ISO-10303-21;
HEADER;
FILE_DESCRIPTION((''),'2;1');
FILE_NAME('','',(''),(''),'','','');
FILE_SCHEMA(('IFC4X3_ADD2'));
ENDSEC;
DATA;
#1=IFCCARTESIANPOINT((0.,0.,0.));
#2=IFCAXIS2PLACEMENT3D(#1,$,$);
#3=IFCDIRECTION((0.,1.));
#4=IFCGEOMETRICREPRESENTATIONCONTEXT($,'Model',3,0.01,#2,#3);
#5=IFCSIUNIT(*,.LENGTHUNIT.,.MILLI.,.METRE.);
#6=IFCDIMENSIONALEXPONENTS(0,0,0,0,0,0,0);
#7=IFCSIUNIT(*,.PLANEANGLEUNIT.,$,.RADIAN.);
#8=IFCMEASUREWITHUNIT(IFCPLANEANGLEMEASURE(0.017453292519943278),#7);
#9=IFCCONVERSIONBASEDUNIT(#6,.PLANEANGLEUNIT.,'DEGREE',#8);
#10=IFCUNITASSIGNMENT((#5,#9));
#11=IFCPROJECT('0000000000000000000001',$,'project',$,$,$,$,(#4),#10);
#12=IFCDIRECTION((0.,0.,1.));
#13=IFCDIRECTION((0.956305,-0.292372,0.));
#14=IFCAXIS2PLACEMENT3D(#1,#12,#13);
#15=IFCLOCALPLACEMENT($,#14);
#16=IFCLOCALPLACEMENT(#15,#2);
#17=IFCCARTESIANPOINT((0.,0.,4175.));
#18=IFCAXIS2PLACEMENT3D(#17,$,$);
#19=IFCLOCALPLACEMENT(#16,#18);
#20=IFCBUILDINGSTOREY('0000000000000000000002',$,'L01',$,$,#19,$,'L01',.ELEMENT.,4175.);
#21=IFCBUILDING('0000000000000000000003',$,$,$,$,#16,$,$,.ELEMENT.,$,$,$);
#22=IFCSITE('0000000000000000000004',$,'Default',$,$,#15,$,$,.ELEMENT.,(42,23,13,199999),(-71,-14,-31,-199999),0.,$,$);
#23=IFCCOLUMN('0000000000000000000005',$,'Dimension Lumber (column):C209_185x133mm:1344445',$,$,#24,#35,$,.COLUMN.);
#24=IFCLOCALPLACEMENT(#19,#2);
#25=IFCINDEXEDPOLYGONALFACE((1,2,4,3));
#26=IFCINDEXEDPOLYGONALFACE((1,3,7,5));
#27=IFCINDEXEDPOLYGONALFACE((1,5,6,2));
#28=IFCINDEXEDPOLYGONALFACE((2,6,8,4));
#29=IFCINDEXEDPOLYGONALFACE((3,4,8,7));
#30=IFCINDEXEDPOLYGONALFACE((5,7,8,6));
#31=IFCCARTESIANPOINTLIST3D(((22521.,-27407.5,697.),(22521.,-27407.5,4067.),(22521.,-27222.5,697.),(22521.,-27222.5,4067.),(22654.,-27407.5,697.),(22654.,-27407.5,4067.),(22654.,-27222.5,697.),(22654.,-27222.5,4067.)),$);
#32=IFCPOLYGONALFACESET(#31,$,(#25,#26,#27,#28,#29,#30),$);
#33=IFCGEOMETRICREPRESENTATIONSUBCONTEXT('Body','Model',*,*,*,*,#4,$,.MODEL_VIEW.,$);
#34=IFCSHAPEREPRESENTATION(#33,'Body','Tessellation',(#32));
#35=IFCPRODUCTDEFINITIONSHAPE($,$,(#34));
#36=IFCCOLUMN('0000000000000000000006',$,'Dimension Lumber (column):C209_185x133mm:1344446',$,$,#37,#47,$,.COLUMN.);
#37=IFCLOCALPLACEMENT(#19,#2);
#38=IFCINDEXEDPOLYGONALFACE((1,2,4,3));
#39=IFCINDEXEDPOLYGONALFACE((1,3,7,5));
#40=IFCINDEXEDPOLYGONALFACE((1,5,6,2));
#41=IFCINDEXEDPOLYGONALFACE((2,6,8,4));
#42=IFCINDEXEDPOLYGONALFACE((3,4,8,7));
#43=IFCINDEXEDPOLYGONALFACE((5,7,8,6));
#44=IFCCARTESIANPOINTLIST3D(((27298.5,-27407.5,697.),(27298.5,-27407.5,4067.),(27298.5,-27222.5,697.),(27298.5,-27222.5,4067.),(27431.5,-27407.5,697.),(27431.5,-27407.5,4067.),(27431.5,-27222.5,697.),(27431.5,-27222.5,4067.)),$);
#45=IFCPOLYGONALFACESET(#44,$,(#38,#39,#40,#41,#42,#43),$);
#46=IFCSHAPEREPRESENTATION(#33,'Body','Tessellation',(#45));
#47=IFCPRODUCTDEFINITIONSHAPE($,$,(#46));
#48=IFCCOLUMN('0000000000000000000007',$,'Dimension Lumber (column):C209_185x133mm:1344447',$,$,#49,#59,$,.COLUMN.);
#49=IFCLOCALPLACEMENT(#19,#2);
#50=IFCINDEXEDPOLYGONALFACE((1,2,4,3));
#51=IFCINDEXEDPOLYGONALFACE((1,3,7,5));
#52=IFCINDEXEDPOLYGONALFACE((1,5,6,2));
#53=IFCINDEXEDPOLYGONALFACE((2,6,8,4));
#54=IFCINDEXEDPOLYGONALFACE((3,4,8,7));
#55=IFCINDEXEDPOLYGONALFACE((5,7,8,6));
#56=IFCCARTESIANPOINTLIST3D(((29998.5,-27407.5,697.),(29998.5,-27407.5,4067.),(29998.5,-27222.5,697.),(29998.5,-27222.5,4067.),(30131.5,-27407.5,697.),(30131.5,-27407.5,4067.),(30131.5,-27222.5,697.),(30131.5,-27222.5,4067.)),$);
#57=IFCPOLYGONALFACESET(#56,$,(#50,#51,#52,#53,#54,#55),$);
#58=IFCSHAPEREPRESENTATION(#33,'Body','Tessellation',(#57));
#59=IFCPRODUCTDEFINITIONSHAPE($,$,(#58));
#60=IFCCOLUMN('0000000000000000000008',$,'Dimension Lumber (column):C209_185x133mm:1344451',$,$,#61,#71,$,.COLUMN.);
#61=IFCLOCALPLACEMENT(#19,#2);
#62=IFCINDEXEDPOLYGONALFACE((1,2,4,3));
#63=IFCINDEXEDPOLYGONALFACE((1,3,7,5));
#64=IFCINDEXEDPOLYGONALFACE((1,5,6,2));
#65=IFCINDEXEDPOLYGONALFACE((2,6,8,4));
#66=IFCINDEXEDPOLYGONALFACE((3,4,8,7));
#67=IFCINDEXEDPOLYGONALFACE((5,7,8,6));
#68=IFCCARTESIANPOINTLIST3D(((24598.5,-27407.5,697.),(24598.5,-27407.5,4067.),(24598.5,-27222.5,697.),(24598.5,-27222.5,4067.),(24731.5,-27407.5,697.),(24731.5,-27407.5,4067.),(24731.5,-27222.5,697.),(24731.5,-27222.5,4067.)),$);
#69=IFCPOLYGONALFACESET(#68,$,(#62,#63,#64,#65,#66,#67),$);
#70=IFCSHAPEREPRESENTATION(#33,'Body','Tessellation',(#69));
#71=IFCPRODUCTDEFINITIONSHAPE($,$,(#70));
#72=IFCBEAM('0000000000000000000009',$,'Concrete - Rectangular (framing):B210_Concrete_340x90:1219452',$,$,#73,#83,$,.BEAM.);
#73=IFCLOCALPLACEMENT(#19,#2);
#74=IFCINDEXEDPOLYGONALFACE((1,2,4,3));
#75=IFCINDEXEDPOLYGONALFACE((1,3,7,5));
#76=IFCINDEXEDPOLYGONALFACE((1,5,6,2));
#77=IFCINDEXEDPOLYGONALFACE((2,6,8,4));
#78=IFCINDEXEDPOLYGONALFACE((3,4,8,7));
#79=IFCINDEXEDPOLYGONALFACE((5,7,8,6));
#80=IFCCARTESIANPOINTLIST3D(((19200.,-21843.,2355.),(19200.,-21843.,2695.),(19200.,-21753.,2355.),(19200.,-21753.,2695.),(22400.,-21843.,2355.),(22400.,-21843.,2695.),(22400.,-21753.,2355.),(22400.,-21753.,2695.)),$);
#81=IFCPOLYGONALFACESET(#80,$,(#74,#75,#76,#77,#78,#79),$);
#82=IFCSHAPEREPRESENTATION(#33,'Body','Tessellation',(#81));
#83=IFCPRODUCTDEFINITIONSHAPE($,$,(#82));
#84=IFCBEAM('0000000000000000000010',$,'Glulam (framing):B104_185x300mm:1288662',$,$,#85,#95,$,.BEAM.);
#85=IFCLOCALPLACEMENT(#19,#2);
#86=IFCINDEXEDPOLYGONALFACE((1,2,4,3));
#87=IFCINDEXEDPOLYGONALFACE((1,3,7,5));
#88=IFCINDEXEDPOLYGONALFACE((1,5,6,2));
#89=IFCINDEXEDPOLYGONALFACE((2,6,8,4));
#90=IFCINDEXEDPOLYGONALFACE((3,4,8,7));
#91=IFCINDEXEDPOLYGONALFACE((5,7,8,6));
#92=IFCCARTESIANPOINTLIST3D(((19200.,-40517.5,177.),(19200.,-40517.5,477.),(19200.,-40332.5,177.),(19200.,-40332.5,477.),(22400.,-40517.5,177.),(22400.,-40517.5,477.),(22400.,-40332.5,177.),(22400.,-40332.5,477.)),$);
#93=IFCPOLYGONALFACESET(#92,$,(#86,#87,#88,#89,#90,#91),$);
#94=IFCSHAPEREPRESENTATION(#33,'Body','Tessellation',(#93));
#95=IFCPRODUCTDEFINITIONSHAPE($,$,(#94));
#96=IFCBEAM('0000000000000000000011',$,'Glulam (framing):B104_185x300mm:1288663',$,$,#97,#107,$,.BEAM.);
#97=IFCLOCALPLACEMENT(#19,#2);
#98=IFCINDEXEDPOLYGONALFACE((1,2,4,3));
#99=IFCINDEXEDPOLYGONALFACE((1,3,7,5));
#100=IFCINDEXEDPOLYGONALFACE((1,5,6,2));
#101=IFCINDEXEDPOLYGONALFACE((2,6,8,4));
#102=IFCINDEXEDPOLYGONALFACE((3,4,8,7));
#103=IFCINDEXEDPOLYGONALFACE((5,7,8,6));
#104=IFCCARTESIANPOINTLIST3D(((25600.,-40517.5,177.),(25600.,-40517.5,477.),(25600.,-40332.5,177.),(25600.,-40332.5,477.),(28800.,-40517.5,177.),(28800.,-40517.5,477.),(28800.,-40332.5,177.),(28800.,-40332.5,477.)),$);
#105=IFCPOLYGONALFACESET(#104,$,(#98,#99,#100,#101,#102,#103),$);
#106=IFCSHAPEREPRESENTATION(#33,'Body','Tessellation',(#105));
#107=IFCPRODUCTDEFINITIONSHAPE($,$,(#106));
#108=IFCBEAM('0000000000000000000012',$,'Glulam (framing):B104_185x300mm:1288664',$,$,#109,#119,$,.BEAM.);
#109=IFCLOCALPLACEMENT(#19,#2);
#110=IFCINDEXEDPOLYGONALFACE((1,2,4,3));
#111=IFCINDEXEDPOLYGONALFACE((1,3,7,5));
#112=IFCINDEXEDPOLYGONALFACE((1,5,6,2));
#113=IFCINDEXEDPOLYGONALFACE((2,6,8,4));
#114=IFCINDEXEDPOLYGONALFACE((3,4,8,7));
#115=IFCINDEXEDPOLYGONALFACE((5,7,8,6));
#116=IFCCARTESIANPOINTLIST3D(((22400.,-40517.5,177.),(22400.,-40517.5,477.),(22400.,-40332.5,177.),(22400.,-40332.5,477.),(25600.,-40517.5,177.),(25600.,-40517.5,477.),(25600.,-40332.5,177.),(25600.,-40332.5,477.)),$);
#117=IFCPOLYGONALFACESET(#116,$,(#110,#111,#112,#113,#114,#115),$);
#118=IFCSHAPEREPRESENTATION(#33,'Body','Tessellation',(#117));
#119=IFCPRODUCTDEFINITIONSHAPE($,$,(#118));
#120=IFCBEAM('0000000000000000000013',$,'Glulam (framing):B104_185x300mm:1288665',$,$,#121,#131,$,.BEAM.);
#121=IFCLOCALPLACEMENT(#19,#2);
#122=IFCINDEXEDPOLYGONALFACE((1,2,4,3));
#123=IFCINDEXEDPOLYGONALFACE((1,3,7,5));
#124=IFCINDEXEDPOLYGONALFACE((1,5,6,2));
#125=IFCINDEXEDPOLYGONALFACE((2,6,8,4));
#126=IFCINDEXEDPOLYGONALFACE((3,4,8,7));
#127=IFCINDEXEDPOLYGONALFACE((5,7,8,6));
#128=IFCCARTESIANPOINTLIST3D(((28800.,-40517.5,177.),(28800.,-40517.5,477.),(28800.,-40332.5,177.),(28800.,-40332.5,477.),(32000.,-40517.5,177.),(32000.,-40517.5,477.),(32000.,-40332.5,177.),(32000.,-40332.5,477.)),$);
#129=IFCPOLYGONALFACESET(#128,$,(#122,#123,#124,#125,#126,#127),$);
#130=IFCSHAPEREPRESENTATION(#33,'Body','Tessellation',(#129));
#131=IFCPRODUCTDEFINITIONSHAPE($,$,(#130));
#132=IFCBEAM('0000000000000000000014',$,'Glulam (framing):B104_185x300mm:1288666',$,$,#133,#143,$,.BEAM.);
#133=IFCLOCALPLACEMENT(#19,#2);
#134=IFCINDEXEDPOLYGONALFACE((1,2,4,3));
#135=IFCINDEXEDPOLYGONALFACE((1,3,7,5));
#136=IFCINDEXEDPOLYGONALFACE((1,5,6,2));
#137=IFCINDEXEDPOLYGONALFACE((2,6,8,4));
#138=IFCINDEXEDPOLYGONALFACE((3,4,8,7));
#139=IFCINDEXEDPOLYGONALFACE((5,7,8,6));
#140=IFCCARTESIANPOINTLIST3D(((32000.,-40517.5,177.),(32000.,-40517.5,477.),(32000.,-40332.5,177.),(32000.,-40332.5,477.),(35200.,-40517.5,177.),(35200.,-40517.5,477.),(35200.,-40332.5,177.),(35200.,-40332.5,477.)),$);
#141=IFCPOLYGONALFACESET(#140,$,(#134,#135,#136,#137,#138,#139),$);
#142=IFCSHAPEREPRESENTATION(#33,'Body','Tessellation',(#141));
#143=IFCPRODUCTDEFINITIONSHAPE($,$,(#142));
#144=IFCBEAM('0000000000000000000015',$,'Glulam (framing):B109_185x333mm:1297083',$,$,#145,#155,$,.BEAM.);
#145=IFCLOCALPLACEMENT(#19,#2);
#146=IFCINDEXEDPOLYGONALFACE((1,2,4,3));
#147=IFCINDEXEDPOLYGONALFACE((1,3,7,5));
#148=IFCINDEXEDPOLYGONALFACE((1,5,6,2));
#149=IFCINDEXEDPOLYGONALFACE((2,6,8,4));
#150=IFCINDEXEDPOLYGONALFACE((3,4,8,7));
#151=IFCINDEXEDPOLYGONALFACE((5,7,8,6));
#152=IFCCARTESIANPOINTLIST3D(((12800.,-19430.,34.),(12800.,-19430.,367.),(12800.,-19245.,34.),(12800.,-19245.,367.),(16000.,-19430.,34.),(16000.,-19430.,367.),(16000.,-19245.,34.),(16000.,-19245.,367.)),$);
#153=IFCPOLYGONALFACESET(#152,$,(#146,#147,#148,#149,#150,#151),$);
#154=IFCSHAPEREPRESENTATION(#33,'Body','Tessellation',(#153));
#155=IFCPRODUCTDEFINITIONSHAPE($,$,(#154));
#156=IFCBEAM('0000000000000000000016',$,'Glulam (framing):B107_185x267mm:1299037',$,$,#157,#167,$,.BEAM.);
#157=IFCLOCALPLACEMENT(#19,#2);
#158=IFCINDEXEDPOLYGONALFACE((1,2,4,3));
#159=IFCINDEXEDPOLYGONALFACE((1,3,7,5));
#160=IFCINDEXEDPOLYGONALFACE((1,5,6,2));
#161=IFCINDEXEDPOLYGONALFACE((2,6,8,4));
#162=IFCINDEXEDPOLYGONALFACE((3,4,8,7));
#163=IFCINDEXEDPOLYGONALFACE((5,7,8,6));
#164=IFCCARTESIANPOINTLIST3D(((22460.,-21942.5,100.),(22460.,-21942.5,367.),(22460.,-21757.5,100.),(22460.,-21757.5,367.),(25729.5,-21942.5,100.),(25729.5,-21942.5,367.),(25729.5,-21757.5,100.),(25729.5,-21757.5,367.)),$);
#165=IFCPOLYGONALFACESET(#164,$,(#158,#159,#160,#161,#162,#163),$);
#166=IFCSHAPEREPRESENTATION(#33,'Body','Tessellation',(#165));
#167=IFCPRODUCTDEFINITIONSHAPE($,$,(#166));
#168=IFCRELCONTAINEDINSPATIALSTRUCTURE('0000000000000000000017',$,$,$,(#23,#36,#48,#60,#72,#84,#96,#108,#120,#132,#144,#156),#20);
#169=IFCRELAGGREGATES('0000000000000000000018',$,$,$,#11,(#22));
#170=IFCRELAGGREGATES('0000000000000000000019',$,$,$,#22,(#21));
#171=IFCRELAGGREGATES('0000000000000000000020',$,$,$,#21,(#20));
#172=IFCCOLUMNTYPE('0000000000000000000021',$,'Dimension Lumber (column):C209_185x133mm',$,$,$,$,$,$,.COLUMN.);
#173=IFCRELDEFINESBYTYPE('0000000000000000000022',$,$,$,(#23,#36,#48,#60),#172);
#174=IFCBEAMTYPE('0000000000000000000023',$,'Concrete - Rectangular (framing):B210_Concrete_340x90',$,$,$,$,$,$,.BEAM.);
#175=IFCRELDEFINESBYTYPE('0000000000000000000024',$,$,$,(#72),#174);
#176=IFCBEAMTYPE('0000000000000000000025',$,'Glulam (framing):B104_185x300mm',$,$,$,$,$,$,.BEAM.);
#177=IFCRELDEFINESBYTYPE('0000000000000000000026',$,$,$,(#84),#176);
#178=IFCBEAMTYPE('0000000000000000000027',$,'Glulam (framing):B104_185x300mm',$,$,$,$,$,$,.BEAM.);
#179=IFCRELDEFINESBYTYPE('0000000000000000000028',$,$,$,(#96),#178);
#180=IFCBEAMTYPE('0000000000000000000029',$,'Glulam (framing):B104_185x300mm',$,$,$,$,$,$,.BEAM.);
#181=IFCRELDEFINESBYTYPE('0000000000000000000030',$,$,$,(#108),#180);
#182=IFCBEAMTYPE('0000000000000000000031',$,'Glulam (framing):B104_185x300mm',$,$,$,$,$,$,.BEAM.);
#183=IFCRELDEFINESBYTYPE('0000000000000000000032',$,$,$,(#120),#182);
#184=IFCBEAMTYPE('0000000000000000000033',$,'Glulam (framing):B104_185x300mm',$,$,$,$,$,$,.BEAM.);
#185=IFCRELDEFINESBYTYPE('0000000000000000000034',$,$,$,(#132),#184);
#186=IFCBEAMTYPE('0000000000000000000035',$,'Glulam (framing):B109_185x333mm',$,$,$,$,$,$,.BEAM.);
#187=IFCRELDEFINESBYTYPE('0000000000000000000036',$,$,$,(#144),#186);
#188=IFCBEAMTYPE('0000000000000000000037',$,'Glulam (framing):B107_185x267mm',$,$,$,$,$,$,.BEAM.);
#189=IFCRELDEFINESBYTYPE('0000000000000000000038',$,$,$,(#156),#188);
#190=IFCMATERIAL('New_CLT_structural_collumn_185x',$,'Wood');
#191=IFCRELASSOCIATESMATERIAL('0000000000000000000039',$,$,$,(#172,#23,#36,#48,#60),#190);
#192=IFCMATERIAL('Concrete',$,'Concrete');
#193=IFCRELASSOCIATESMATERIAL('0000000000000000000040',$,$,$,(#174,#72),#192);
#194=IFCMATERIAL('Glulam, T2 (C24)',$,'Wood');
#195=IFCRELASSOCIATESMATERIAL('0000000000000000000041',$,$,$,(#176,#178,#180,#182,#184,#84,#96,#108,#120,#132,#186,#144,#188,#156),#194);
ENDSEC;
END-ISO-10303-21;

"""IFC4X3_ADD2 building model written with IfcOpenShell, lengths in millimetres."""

from ifc_helpers import new_model, entity, si_unit, converted_unit, direction, frame, origin, origin_2d_with_axis, place, context, subcontext, project, spatial, rectangle, extrude, source, transform, mapped, material, material_profile, profile_set, profile_usage, type_object, type_shapes, element, save


model = new_model("IFC4X3_ADD2")

# Units and contexts
model_context = context("Model", 3, precision=0.01, world=origin(), true_north=direction((0.0, 1.0)))
body_context = subcontext(model_context, "Body", "Model", "MODEL_VIEW")
ifc_project = project(units=[si_unit("LENGTHUNIT", "METRE", prefix="MILLI"), converted_unit("PLANEANGLEUNIT", "DEGREE", entity("IfcPlaneAngleMeasure", 0.017453292519943278), si_unit("PLANEANGLEUNIT", "RADIAN"), dimensions=[0, 0, 0, 0, 0, 0, 0])], contexts=[model_context])

# Site, building, storey
site_placement = place(None, frame((0.0, 0.0, 0.0), z_axis=(0.0, 0.0, 1.0), x_axis=(0.956305, -0.292372, 0.0)))
site = spatial("IfcSite", under=ifc_project, at=site_placement, Name="Default", CompositionType="ELEMENT", RefLatitude=(42, 23, 13, 199999), RefLongitude=(-71, -14, -31, -199999), RefElevation=0.0)
building_placement = place(site_placement, origin())
building = spatial("IfcBuilding", under=site, at=building_placement, CompositionType="ELEMENT")
storey_placement = place(building_placement, frame((0.0, 0.0, 4175.0)))
storey = spatial("IfcBuildingStorey", under=building, at=storey_placement, Name="L01", LongName="L01", CompositionType="ELEMENT", Elevation=4175.0)

# Columns
ifc_material_1 = material(Name="New_CLT_structural_collumn_185x", Category="Wood")
ifc_material_profile_1 = material_profile(ifc_material_1, rectangle(XDim=185.0, YDim=133.0, at=origin_2d_with_axis()), Name="C209_185x133mm")
ifc_profile_set_1 = profile_set([ifc_material_profile_1], Name="C209_185x133mm")
ifc_profile_usage_1 = profile_usage(ifc_profile_set_1)
column_type_1 = type_object("IfcColumnType", Name="Dimension Lumber (column):C209_185x133mm", PredefinedType="COLUMN", material=ifc_profile_set_1)
shared_shape_1 = source(origin(), body_context, "Body", "SweptSolid", [
    extrude(rectangle(XDim=185.0, YDim=133.0, at=origin_2d_with_axis()), frame((0.0, 0.0, 4872.0), z_axis=(0.0, 0.0, 1.0), x_axis=(-1.0, 0.0, 0.0)), (0.0, 0.0, 1.0), 3370.0),
])
type_shapes(column_type_1, [shared_shape_1])
for number, where, z_axis, x_axis, name in (
    (1, (22587.5, -27315.0, -4175.0), (0.0, 0.0, 1.0), (0.0, 1.0, 0.0), "Dimension Lumber (column):C209_185x133mm:1344445"),
    (2, (27365.0, -27315.0, -4175.0), (0.0, 0.0, 1.0), (0.0, 1.0, 0.0), "Dimension Lumber (column):C209_185x133mm:1344446"),
    (3, (30065.0, -27315.0, -4175.0), (0.0, 0.0, 1.0), (0.0, 1.0, 0.0), "Dimension Lumber (column):C209_185x133mm:1344447"),
    (4, (24665.0, -27315.0, -4175.0), (0.0, 0.0, 1.0), (0.0, 1.0, 0.0), "Dimension Lumber (column):C209_185x133mm:1344451"),
):
    element("IfcColumn", number, at=place(storey_placement, frame(where, z_axis=z_axis, x_axis=x_axis)), inside=storey, type_object=column_type_1, material=ifc_profile_usage_1, Name=name, PredefinedType="COLUMN", context=body_context, shape_type="MappedRepresentation", body=[
        mapped(shared_shape_1, transform((0.0, 0.0, 0.0), scale=1.0)),
    ])

# Beams
ifc_material_2 = material(Name="Concrete", Category="Concrete")
ifc_material_profile_2 = material_profile(ifc_material_2, rectangle(XDim=3200.0, YDim=90.0, at=origin_2d_with_axis()), Name="B210_Concrete_340x90")
ifc_profile_set_2 = profile_set([ifc_material_profile_2], Name="B210_Concrete_340x90")
ifc_profile_usage_2 = profile_usage(ifc_profile_set_2, cardinal=8)
beam_type_1 = type_object("IfcBeamType", Name="Concrete - Rectangular (framing):B210_Concrete_340x90", PredefinedType="BEAM", material=ifc_profile_set_2)
shared_shape_2 = source(origin(), body_context, "Body", "SweptSolid", [
    extrude(rectangle(XDim=3200.0, YDim=90.0, at=origin_2d_with_axis()), frame((0.0, 0.0, -170.0), z_axis=(0.0, 0.0, 1.0), x_axis=(-1.0, 0.0, 0.0)), (0.0, 0.0, 1.0), 340.0),
])
type_shapes(beam_type_1, [shared_shape_2])
beam_1_placement = place(storey_placement, frame((20800.0, -21798.0, 2525.0)))
element("IfcBeam", 5, at=beam_1_placement, inside=storey, type_object=beam_type_1, material=ifc_profile_usage_2, Name="Concrete - Rectangular (framing):B210_Concrete_340x90:1219452", PredefinedType="BEAM", context=body_context, shape_type="MappedRepresentation", body=[
    mapped(shared_shape_2, transform((0.0, 0.0, 0.0), scale=1.0)),
])
ifc_material_3 = material(Name="Glulam, T2 (C24)", Category="Wood")
ifc_material_profile_3 = material_profile(ifc_material_3, rectangle(XDim=3380.0, YDim=185.0, at=origin_2d_with_axis()), Name="B104_185x300mm")
ifc_profile_set_3 = profile_set([ifc_material_profile_3], Name="B104_185x300mm")
ifc_profile_usage_3 = profile_usage(ifc_profile_set_3, cardinal=8)
beam_type_2 = type_object("IfcBeamType", Name="Glulam (framing):B104_185x300mm", PredefinedType="BEAM", material=ifc_profile_set_3)
shared_shape_3 = source(origin(), body_context, "Body", "SweptSolid", [
    extrude(rectangle(XDim=3200.0, YDim=185.0, at=origin_2d_with_axis()), frame((0.0, 0.0, -150.0), z_axis=(0.0, 0.0, 1.0), x_axis=(-1.0, 0.0, 0.0)), (0.0, 0.0, 1.0), 300.0),
])
type_shapes(beam_type_2, [shared_shape_3])
beam_2_placement = place(storey_placement, frame((20800.0, -40425.0, 327.0)))
element("IfcBeam", 6, at=beam_2_placement, inside=storey, type_object=beam_type_2, material=ifc_profile_usage_3, Name="Glulam (framing):B104_185x300mm:1288662", PredefinedType="BEAM", context=body_context, shape_type="MappedRepresentation", body=[
    mapped(shared_shape_3, transform((0.0, 0.0, 0.0), scale=1.0)),
])
beam_type_3 = type_object("IfcBeamType", Name="Glulam (framing):B104_185x300mm", PredefinedType="BEAM", material=ifc_profile_set_3)
shared_shape_4 = source(origin(), body_context, "Body", "SweptSolid", [
    extrude(rectangle(XDim=3200.0, YDim=185.0, at=origin_2d_with_axis()), frame((0.0, 0.0, -150.0), z_axis=(0.0, 0.0, 1.0), x_axis=(-1.0, 0.0, 0.0)), (0.0, 0.0, 1.0), 300.0),
])
type_shapes(beam_type_3, [shared_shape_4])
beam_3_placement = place(storey_placement, frame((27200.0, -40425.0, 327.0)))
element("IfcBeam", 7, at=beam_3_placement, inside=storey, type_object=beam_type_3, material=ifc_profile_usage_3, Name="Glulam (framing):B104_185x300mm:1288663", PredefinedType="BEAM", context=body_context, shape_type="MappedRepresentation", body=[
    mapped(shared_shape_4, transform((0.0, 0.0, 0.0), scale=1.0)),
])
beam_type_4 = type_object("IfcBeamType", Name="Glulam (framing):B104_185x300mm", PredefinedType="BEAM", material=ifc_profile_set_3)
shared_shape_5 = source(origin(), body_context, "Body", "SweptSolid", [
    extrude(rectangle(XDim=3200.0, YDim=185.0, at=origin_2d_with_axis()), frame((0.0, 0.0, -150.0), z_axis=(0.0, 0.0, 1.0), x_axis=(-1.0, 0.0, 0.0)), (0.0, 0.0, 1.0), 300.0),
])
type_shapes(beam_type_4, [shared_shape_5])
beam_4_placement = place(storey_placement, frame((24000.0, -40425.0, 327.0)))
element("IfcBeam", 8, at=beam_4_placement, inside=storey, type_object=beam_type_4, material=ifc_profile_usage_3, Name="Glulam (framing):B104_185x300mm:1288664", PredefinedType="BEAM", context=body_context, shape_type="MappedRepresentation", body=[
    mapped(shared_shape_5, transform((0.0, 0.0, 0.0), scale=1.0)),
])
beam_type_5 = type_object("IfcBeamType", Name="Glulam (framing):B104_185x300mm", PredefinedType="BEAM", material=ifc_profile_set_3)
shared_shape_6 = source(origin(), body_context, "Body", "SweptSolid", [
    extrude(rectangle(XDim=3200.0, YDim=185.0, at=origin_2d_with_axis()), frame((0.0, 0.0, -150.0), z_axis=(0.0, 0.0, 1.0), x_axis=(-1.0, 0.0, 0.0)), (0.0, 0.0, 1.0), 300.0),
])
type_shapes(beam_type_5, [shared_shape_6])
beam_5_placement = place(storey_placement, frame((30400.0, -40425.0, 327.0)))
element("IfcBeam", 9, at=beam_5_placement, inside=storey, type_object=beam_type_5, material=ifc_profile_usage_3, Name="Glulam (framing):B104_185x300mm:1288665", PredefinedType="BEAM", context=body_context, shape_type="MappedRepresentation", body=[
    mapped(shared_shape_6, transform((0.0, 0.0, 0.0), scale=1.0)),
])
beam_type_6 = type_object("IfcBeamType", Name="Glulam (framing):B104_185x300mm", PredefinedType="BEAM", material=ifc_profile_set_3)
shared_shape_7 = source(origin(), body_context, "Body", "SweptSolid", [
    extrude(rectangle(XDim=3200.0, YDim=185.0, at=origin_2d_with_axis()), frame((0.0, 0.0, -150.0), z_axis=(0.0, 0.0, 1.0), x_axis=(-1.0, 0.0, 0.0)), (0.0, 0.0, 1.0), 300.0),
])
type_shapes(beam_type_6, [shared_shape_7])
beam_6_placement = place(storey_placement, frame((33600.0, -40425.0, 327.0)))
element("IfcBeam", 10, at=beam_6_placement, inside=storey, type_object=beam_type_6, material=ifc_profile_usage_3, Name="Glulam (framing):B104_185x300mm:1288666", PredefinedType="BEAM", context=body_context, shape_type="MappedRepresentation", body=[
    mapped(shared_shape_7, transform((0.0, 0.0, 0.0), scale=1.0)),
])
ifc_material_profile_4 = material_profile(ifc_material_3, rectangle(XDim=185.0, YDim=3200.0, at=origin_2d_with_axis()), Name="B109_185x333mm")
ifc_profile_set_4 = profile_set([ifc_material_profile_4], Name="B109_185x333mm")
ifc_profile_usage_4 = profile_usage(ifc_profile_set_4, cardinal=8)
beam_type_7 = type_object("IfcBeamType", Name="Glulam (framing):B109_185x333mm", PredefinedType="BEAM", material=ifc_profile_set_4)
shared_shape_8 = source(origin(), body_context, "Body", "SweptSolid", [
    extrude(rectangle(XDim=185.0, YDim=3200.0, at=origin_2d_with_axis()), frame((0.0, 0.0, -166.5), z_axis=(0.0, 0.0, 1.0), x_axis=(0.0, 1.0, 0.0)), (0.0, 0.0, 1.0), 333.0),
])
type_shapes(beam_type_7, [shared_shape_8])
beam_7_placement = place(storey_placement, frame((14400.0, -19337.5, 200.5), z_axis=(0.0, 0.0, 1.0), x_axis=(-1.0, 0.0, 0.0)))
element("IfcBeam", 11, at=beam_7_placement, inside=storey, type_object=beam_type_7, material=ifc_profile_usage_4, Name="Glulam (framing):B109_185x333mm:1297083", PredefinedType="BEAM", context=body_context, shape_type="MappedRepresentation", body=[
    mapped(shared_shape_8, transform((0.0, 0.0, 0.0), scale=1.0)),
])
ifc_material_profile_5 = material_profile(ifc_material_3, rectangle(XDim=3269.5, YDim=185.0, at=origin_2d_with_axis()), Name="B107_185x267mm")
ifc_profile_set_5 = profile_set([ifc_material_profile_5], Name="B107_185x267mm")
ifc_profile_usage_5 = profile_usage(ifc_profile_set_5, cardinal=8)
beam_type_8 = type_object("IfcBeamType", Name="Glulam (framing):B107_185x267mm", PredefinedType="BEAM", material=ifc_profile_set_5)
shared_shape_9 = source(origin(), body_context, "Body", "SweptSolid", [
    extrude(rectangle(XDim=3269.5, YDim=185.0, at=origin_2d_with_axis()), frame((3.5, 0.0, -133.5), z_axis=(0.0, 0.0, 1.0), x_axis=(-1.0, 0.0, 0.0)), (0.0, 0.0, 1.0), 267.0),
])
type_shapes(beam_type_8, [shared_shape_9])
beam_8_placement = place(storey_placement, frame((24091.3, -21850.0, 233.5)))
element("IfcBeam", 12, at=beam_8_placement, inside=storey, type_object=beam_type_8, material=ifc_profile_usage_5, Name="Glulam (framing):B107_185x267mm:1299037", PredefinedType="BEAM", context=body_context, shape_type="MappedRepresentation", body=[
    mapped(shared_shape_9, transform((0.0, 0.0, 0.0), scale=1.0)),
])

save(model, "model.ifc")
